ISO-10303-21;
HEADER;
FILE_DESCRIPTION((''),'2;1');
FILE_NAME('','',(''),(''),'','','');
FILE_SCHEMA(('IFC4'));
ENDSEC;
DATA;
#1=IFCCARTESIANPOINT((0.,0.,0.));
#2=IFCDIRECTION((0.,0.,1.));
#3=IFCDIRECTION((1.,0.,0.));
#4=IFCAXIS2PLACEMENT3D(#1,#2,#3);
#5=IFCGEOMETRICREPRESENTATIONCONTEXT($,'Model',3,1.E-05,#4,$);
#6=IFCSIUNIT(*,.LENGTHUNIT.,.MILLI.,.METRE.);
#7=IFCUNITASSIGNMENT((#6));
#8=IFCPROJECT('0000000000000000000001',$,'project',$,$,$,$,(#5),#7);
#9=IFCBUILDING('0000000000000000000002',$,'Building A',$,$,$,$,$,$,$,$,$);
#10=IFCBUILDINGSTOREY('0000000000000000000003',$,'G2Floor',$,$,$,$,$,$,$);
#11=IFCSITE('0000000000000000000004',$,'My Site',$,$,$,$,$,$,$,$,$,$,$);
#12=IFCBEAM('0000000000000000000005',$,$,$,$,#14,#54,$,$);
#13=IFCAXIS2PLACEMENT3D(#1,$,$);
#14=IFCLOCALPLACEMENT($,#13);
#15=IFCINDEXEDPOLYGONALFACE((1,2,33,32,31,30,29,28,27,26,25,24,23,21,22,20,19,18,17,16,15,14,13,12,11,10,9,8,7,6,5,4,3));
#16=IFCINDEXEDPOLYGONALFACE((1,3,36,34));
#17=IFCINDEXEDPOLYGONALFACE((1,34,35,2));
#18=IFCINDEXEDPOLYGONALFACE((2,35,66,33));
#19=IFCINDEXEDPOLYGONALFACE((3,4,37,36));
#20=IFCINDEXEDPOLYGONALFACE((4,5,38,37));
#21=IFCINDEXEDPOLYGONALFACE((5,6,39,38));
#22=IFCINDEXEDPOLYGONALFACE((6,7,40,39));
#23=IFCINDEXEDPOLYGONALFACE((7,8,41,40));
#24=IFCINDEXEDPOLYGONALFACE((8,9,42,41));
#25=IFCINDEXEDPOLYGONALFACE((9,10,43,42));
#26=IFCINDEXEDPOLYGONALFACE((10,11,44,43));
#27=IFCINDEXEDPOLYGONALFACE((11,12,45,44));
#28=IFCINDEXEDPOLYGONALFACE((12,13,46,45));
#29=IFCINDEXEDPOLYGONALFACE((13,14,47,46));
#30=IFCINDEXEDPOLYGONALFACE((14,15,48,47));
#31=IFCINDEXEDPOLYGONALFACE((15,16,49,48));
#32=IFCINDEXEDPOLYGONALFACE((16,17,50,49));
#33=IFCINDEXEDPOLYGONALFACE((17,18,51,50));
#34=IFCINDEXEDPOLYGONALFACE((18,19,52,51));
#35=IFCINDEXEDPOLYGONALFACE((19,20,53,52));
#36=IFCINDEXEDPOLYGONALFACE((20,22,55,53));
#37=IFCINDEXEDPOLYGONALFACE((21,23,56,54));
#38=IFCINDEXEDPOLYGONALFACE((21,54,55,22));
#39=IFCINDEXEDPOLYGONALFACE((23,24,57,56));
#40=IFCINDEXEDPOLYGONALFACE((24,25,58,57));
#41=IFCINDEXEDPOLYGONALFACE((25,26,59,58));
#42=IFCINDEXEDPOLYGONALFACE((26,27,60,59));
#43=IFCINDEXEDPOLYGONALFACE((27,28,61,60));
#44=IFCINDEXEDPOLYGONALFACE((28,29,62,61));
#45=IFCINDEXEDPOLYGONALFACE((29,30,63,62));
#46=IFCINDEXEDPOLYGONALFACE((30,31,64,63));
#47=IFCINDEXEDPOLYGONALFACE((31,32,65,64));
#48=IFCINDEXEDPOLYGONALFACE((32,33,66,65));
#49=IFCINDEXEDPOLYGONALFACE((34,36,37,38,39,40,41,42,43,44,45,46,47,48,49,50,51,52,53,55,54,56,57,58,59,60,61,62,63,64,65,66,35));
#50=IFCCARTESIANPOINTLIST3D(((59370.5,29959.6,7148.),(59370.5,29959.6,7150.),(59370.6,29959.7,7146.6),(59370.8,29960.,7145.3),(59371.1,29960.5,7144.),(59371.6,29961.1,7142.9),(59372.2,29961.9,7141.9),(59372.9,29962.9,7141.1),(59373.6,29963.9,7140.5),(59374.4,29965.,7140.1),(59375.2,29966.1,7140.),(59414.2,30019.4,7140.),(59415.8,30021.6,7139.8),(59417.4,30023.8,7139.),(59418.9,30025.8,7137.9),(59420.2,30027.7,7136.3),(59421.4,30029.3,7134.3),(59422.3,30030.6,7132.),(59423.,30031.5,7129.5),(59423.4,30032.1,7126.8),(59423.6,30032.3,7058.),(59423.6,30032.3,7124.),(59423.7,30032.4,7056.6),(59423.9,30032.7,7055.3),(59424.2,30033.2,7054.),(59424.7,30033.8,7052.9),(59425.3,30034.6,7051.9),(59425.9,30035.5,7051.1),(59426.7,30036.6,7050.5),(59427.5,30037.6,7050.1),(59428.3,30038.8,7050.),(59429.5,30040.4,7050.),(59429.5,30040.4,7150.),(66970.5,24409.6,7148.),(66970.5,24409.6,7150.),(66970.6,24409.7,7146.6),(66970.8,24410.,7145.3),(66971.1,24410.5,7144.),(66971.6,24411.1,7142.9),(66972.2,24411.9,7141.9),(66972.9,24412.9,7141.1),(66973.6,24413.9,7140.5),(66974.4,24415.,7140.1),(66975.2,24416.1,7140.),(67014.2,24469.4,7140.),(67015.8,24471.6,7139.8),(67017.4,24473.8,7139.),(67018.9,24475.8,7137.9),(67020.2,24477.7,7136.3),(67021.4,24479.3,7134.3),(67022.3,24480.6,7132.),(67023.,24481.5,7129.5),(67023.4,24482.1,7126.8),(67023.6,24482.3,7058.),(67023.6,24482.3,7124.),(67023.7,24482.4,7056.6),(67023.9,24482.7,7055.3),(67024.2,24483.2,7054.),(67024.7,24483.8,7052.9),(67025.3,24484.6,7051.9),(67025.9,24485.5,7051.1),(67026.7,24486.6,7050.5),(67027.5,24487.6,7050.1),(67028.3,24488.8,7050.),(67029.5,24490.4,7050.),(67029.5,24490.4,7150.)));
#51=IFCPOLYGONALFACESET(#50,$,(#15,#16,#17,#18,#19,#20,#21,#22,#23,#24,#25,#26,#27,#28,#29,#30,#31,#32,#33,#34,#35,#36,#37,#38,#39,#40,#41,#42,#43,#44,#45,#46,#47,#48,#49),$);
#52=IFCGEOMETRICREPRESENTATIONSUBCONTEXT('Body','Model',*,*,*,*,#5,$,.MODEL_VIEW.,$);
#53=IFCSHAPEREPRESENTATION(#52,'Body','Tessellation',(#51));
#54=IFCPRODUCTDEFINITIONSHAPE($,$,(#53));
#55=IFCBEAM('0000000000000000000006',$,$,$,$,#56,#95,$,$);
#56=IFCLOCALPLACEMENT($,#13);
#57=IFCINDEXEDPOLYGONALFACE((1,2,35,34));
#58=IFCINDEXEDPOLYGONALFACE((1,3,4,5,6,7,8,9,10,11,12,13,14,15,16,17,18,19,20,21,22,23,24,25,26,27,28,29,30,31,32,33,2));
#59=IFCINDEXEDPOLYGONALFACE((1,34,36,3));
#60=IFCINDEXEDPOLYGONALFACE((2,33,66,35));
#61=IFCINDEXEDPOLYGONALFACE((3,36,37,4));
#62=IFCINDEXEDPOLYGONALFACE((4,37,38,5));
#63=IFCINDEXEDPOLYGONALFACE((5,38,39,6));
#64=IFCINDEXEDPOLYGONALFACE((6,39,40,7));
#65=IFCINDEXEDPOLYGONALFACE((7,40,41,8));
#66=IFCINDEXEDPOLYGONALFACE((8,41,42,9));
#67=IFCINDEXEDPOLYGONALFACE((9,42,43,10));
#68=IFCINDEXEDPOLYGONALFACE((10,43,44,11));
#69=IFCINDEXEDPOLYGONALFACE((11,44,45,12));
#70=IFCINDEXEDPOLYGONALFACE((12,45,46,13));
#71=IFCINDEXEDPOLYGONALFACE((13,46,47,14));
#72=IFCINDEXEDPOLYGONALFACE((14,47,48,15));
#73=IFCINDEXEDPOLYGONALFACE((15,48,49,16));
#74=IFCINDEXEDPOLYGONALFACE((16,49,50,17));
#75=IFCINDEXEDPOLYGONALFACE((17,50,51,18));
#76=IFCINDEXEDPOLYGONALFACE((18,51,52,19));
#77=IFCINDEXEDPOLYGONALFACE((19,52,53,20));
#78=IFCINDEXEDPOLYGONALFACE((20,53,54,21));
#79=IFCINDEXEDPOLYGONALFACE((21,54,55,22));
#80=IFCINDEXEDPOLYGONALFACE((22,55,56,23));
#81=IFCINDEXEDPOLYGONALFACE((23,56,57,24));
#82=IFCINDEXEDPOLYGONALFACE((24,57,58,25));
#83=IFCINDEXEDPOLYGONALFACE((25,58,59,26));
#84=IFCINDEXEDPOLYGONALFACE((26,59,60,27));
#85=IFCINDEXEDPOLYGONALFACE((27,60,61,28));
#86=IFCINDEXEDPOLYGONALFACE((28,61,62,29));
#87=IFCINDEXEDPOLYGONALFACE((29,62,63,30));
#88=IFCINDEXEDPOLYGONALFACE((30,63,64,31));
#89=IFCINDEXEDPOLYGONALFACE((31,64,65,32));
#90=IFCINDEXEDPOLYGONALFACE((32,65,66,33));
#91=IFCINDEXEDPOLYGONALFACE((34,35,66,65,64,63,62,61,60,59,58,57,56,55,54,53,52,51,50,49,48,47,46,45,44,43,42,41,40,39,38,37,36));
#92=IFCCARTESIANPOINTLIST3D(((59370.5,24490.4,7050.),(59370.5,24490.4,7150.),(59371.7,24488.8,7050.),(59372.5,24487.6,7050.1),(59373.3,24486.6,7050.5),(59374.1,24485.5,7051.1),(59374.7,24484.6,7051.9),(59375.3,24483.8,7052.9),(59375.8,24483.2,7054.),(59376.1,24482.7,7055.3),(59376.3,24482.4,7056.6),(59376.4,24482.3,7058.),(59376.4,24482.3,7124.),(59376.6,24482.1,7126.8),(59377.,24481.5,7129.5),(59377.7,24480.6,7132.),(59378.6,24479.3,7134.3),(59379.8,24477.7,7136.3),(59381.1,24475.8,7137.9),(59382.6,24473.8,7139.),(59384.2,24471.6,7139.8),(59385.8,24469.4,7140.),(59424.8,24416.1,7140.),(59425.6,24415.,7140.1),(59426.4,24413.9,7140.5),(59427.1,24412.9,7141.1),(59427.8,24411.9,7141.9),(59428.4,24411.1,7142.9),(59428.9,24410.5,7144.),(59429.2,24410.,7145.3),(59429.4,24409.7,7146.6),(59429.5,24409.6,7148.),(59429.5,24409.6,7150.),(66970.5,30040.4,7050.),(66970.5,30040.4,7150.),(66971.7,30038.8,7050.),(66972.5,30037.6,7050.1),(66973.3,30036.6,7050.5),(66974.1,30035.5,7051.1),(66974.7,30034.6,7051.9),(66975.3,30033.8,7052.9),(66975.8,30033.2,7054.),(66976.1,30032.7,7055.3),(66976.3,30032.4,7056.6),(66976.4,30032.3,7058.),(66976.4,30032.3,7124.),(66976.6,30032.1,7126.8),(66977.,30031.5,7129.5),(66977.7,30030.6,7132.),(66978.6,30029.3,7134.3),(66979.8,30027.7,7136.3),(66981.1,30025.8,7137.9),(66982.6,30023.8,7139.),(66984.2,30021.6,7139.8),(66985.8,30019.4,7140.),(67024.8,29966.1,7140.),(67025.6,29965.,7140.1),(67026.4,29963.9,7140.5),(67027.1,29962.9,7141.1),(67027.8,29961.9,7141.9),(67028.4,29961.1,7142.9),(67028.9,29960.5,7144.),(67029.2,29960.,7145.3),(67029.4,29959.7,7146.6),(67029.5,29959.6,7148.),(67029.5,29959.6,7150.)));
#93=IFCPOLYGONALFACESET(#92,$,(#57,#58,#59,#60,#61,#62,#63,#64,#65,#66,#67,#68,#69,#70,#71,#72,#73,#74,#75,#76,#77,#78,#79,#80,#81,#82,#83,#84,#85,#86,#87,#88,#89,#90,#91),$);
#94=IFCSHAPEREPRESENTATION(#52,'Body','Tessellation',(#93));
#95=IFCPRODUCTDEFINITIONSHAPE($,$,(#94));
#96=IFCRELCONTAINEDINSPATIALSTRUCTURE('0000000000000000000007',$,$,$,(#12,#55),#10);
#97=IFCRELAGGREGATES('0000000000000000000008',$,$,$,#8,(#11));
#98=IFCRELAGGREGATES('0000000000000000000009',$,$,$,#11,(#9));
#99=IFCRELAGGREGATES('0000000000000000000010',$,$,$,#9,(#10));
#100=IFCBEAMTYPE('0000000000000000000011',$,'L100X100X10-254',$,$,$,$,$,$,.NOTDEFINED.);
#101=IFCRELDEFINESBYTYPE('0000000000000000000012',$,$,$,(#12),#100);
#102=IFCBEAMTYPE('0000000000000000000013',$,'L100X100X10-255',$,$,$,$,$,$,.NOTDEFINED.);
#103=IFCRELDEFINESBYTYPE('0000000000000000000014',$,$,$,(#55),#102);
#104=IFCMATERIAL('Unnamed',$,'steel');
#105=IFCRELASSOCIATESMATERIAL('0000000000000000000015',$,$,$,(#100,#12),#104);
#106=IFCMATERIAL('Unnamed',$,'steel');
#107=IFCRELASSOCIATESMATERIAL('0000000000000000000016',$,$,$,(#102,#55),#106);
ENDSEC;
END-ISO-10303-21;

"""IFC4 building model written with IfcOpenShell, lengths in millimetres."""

from ifc_helpers import new_model, si_unit, frame, origin_with_axes, place, context, subcontext, project, spatial, polyline, outline, extrude, material, material_profile, profile_set, profile_usage, type_object, element, save


model = new_model("IFC4")

# Units and contexts
model_context = context("Model", 3, precision=1e-05, world=origin_with_axes())
body_context = subcontext(model_context, "Body", "Model", "MODEL_VIEW")
ifc_project = project(units=[si_unit("LENGTHUNIT", "METRE", prefix="MILLI")], contexts=[model_context])

# Site, building, storey
site = spatial("IfcSite", under=ifc_project, Name="My Site")
building = spatial("IfcBuilding", under=site, Name="Building A")
storey = spatial("IfcBuildingStorey", under=building, Name="G2Floor")

# Beams
ifc_material_1 = material(Name="Unnamed", Category="steel")
ifc_material_profile_1 = material_profile(ifc_material_1, outline(polyline([(-50.0, -50.0), (50.0, -50.0), (50.0, -50.0), (50.0, -48.0), (50.0, -48.0), (49.9, -46.6), (49.9, -46.6), (49.5, -45.3), (49.5, -45.3), (48.9, -44.0), (48.9, -44.0), (48.1, -42.9), (48.1, -42.9), (47.1, -41.9), (47.1, -41.9), (46.0, -41.1), (46.0, -41.1), (44.7, -40.5), (44.7, -40.5), (43.4, -40.1), (43.4, -40.1), (42.0, -40.0), (42.0, -40.0), (-24.0, -40.0), (-24.0, -40.0), (-26.8, -39.8), (-26.8, -39.8), (-29.5, -39.0), (-29.5, -39.0), (-32.0, -37.9), (-32.0, -37.9), (-34.3, -36.3), (-34.3, -36.3), (-36.3, -34.3), (-36.3, -34.3), (-37.9, -32.0), (-37.9, -32.0), (-39.0, -29.5), (-39.0, -29.5), (-39.8, -26.8), (-39.8, -26.8), (-40.0, -24.0), (-40.0, -24.0), (-40.0, 42.0), (-40.0, 42.0), (-40.1, 43.4), (-40.1, 43.4), (-40.5, 44.7), (-40.5, 44.7), (-41.1, 46.0), (-41.1, 46.0), (-41.9, 47.1), (-41.9, 47.1), (-42.9, 48.1), (-42.9, 48.1), (-44.0, 48.9), (-44.0, 48.9), (-45.3, 49.5), (-45.3, 49.5), (-46.6, 49.9), (-46.6, 49.9), (-48.0, 50.0), (-48.0, 50.0), (-50.0, 50.0), (-50.0, 50.0), (-50.0, -50.0)])))
ifc_profile_set_1 = profile_set([ifc_material_profile_1], Name="L100X100X10-254")
ifc_profile_usage_1 = profile_usage(ifc_profile_set_1)
beam_type_1 = type_object("IfcBeamType", Name="L100X100X10-254", PredefinedType="NOTDEFINED", material=ifc_profile_set_1)
beam_1_placement = place(None, frame((59400.0, 30000.0, 7100.0), z_axis=(0.807586, -0.58975, 0.0), x_axis=(-0.58975, -0.807586, 0.0)))
element("IfcBeam", 1, at=beam_1_placement, inside=storey, type_object=beam_type_1, material=ifc_profile_usage_1, context=body_context, shape_type="SweptSolid", body=[
    extrude(outline(polyline([(-50.0, -50.0), (50.0, -50.0), (50.0, -50.0), (50.0, -48.0), (50.0, -48.0), (49.9, -46.6), (49.9, -46.6), (49.5, -45.3), (49.5, -45.3), (48.9, -44.0), (48.9, -44.0), (48.1, -42.9), (48.1, -42.9), (47.1, -41.9), (47.1, -41.9), (46.0, -41.1), (46.0, -41.1), (44.7, -40.5), (44.7, -40.5), (43.4, -40.1), (43.4, -40.1), (42.0, -40.0), (42.0, -40.0), (-24.0, -40.0), (-24.0, -40.0), (-26.8, -39.8), (-26.8, -39.8), (-29.5, -39.0), (-29.5, -39.0), (-32.0, -37.9), (-32.0, -37.9), (-34.3, -36.3), (-34.3, -36.3), (-36.3, -34.3), (-36.3, -34.3), (-37.9, -32.0), (-37.9, -32.0), (-39.0, -29.5), (-39.0, -29.5), (-39.8, -26.8), (-39.8, -26.8), (-40.0, -24.0), (-40.0, -24.0), (-40.0, 42.0), (-40.0, 42.0), (-40.1, 43.4), (-40.1, 43.4), (-40.5, 44.7), (-40.5, 44.7), (-41.1, 46.0), (-41.1, 46.0), (-41.9, 47.1), (-41.9, 47.1), (-42.9, 48.1), (-42.9, 48.1), (-44.0, 48.9), (-44.0, 48.9), (-45.3, 49.5), (-45.3, 49.5), (-46.6, 49.9), (-46.6, 49.9), (-48.0, 50.0), (-48.0, 50.0), (-50.0, 50.0), (-50.0, 50.0), (-50.0, -50.0)])), origin_with_axes(), (0.0, 0.0, 1.0), 9410.8),
])
ifc_material_2 = material(Name="Unnamed", Category="steel")
ifc_material_profile_2 = material_profile(ifc_material_2, outline(polyline([(-50.0, -50.0), (50.0, -50.0), (50.0, -50.0), (50.0, -48.0), (50.0, -48.0), (49.9, -46.6), (49.9, -46.6), (49.5, -45.3), (49.5, -45.3), (48.9, -44.0), (48.9, -44.0), (48.1, -42.9), (48.1, -42.9), (47.1, -41.9), (47.1, -41.9), (46.0, -41.1), (46.0, -41.1), (44.7, -40.5), (44.7, -40.5), (43.4, -40.1), (43.4, -40.1), (42.0, -40.0), (42.0, -40.0), (-24.0, -40.0), (-24.0, -40.0), (-26.8, -39.8), (-26.8, -39.8), (-29.5, -39.0), (-29.5, -39.0), (-32.0, -37.9), (-32.0, -37.9), (-34.3, -36.3), (-34.3, -36.3), (-36.3, -34.3), (-36.3, -34.3), (-37.9, -32.0), (-37.9, -32.0), (-39.0, -29.5), (-39.0, -29.5), (-39.8, -26.8), (-39.8, -26.8), (-40.0, -24.0), (-40.0, -24.0), (-40.0, 42.0), (-40.0, 42.0), (-40.1, 43.4), (-40.1, 43.4), (-40.5, 44.7), (-40.5, 44.7), (-41.1, 46.0), (-41.1, 46.0), (-41.9, 47.1), (-41.9, 47.1), (-42.9, 48.1), (-42.9, 48.1), (-44.0, 48.9), (-44.0, 48.9), (-45.3, 49.5), (-45.3, 49.5), (-46.6, 49.9), (-46.6, 49.9), (-48.0, 50.0), (-48.0, 50.0), (-50.0, 50.0), (-50.0, 50.0), (-50.0, -50.0)])))
ifc_profile_set_2 = profile_set([ifc_material_profile_2], Name="L100X100X10-255")
ifc_profile_usage_2 = profile_usage(ifc_profile_set_2)
beam_type_2 = type_object("IfcBeamType", Name="L100X100X10-255", PredefinedType="NOTDEFINED", material=ifc_profile_set_2)
beam_2_placement = place(None, frame((59400.0, 24450.0, 7100.0), z_axis=(0.807586, 0.58975, 0.0), x_axis=(0.58975, -0.807586, 0.0)))
element("IfcBeam", 2, at=beam_2_placement, inside=storey, type_object=beam_type_2, material=ifc_profile_usage_2, context=body_context, shape_type="SweptSolid", body=[
    extrude(outline(polyline([(-50.0, -50.0), (50.0, -50.0), (50.0, -50.0), (50.0, -48.0), (50.0, -48.0), (49.9, -46.6), (49.9, -46.6), (49.5, -45.3), (49.5, -45.3), (48.9, -44.0), (48.9, -44.0), (48.1, -42.9), (48.1, -42.9), (47.1, -41.9), (47.1, -41.9), (46.0, -41.1), (46.0, -41.1), (44.7, -40.5), (44.7, -40.5), (43.4, -40.1), (43.4, -40.1), (42.0, -40.0), (42.0, -40.0), (-24.0, -40.0), (-24.0, -40.0), (-26.8, -39.8), (-26.8, -39.8), (-29.5, -39.0), (-29.5, -39.0), (-32.0, -37.9), (-32.0, -37.9), (-34.3, -36.3), (-34.3, -36.3), (-36.3, -34.3), (-36.3, -34.3), (-37.9, -32.0), (-37.9, -32.0), (-39.0, -29.5), (-39.0, -29.5), (-39.8, -26.8), (-39.8, -26.8), (-40.0, -24.0), (-40.0, -24.0), (-40.0, 42.0), (-40.0, 42.0), (-40.1, 43.4), (-40.1, 43.4), (-40.5, 44.7), (-40.5, 44.7), (-41.1, 46.0), (-41.1, 46.0), (-41.9, 47.1), (-41.9, 47.1), (-42.9, 48.1), (-42.9, 48.1), (-44.0, 48.9), (-44.0, 48.9), (-45.3, 49.5), (-45.3, 49.5), (-46.6, 49.9), (-46.6, 49.9), (-48.0, 50.0), (-48.0, 50.0), (-50.0, 50.0), (-50.0, 50.0), (-50.0, -50.0)])), origin_with_axes(), (0.0, 0.0, 1.0), 9410.8),
])

save(model, "model.ifc")
